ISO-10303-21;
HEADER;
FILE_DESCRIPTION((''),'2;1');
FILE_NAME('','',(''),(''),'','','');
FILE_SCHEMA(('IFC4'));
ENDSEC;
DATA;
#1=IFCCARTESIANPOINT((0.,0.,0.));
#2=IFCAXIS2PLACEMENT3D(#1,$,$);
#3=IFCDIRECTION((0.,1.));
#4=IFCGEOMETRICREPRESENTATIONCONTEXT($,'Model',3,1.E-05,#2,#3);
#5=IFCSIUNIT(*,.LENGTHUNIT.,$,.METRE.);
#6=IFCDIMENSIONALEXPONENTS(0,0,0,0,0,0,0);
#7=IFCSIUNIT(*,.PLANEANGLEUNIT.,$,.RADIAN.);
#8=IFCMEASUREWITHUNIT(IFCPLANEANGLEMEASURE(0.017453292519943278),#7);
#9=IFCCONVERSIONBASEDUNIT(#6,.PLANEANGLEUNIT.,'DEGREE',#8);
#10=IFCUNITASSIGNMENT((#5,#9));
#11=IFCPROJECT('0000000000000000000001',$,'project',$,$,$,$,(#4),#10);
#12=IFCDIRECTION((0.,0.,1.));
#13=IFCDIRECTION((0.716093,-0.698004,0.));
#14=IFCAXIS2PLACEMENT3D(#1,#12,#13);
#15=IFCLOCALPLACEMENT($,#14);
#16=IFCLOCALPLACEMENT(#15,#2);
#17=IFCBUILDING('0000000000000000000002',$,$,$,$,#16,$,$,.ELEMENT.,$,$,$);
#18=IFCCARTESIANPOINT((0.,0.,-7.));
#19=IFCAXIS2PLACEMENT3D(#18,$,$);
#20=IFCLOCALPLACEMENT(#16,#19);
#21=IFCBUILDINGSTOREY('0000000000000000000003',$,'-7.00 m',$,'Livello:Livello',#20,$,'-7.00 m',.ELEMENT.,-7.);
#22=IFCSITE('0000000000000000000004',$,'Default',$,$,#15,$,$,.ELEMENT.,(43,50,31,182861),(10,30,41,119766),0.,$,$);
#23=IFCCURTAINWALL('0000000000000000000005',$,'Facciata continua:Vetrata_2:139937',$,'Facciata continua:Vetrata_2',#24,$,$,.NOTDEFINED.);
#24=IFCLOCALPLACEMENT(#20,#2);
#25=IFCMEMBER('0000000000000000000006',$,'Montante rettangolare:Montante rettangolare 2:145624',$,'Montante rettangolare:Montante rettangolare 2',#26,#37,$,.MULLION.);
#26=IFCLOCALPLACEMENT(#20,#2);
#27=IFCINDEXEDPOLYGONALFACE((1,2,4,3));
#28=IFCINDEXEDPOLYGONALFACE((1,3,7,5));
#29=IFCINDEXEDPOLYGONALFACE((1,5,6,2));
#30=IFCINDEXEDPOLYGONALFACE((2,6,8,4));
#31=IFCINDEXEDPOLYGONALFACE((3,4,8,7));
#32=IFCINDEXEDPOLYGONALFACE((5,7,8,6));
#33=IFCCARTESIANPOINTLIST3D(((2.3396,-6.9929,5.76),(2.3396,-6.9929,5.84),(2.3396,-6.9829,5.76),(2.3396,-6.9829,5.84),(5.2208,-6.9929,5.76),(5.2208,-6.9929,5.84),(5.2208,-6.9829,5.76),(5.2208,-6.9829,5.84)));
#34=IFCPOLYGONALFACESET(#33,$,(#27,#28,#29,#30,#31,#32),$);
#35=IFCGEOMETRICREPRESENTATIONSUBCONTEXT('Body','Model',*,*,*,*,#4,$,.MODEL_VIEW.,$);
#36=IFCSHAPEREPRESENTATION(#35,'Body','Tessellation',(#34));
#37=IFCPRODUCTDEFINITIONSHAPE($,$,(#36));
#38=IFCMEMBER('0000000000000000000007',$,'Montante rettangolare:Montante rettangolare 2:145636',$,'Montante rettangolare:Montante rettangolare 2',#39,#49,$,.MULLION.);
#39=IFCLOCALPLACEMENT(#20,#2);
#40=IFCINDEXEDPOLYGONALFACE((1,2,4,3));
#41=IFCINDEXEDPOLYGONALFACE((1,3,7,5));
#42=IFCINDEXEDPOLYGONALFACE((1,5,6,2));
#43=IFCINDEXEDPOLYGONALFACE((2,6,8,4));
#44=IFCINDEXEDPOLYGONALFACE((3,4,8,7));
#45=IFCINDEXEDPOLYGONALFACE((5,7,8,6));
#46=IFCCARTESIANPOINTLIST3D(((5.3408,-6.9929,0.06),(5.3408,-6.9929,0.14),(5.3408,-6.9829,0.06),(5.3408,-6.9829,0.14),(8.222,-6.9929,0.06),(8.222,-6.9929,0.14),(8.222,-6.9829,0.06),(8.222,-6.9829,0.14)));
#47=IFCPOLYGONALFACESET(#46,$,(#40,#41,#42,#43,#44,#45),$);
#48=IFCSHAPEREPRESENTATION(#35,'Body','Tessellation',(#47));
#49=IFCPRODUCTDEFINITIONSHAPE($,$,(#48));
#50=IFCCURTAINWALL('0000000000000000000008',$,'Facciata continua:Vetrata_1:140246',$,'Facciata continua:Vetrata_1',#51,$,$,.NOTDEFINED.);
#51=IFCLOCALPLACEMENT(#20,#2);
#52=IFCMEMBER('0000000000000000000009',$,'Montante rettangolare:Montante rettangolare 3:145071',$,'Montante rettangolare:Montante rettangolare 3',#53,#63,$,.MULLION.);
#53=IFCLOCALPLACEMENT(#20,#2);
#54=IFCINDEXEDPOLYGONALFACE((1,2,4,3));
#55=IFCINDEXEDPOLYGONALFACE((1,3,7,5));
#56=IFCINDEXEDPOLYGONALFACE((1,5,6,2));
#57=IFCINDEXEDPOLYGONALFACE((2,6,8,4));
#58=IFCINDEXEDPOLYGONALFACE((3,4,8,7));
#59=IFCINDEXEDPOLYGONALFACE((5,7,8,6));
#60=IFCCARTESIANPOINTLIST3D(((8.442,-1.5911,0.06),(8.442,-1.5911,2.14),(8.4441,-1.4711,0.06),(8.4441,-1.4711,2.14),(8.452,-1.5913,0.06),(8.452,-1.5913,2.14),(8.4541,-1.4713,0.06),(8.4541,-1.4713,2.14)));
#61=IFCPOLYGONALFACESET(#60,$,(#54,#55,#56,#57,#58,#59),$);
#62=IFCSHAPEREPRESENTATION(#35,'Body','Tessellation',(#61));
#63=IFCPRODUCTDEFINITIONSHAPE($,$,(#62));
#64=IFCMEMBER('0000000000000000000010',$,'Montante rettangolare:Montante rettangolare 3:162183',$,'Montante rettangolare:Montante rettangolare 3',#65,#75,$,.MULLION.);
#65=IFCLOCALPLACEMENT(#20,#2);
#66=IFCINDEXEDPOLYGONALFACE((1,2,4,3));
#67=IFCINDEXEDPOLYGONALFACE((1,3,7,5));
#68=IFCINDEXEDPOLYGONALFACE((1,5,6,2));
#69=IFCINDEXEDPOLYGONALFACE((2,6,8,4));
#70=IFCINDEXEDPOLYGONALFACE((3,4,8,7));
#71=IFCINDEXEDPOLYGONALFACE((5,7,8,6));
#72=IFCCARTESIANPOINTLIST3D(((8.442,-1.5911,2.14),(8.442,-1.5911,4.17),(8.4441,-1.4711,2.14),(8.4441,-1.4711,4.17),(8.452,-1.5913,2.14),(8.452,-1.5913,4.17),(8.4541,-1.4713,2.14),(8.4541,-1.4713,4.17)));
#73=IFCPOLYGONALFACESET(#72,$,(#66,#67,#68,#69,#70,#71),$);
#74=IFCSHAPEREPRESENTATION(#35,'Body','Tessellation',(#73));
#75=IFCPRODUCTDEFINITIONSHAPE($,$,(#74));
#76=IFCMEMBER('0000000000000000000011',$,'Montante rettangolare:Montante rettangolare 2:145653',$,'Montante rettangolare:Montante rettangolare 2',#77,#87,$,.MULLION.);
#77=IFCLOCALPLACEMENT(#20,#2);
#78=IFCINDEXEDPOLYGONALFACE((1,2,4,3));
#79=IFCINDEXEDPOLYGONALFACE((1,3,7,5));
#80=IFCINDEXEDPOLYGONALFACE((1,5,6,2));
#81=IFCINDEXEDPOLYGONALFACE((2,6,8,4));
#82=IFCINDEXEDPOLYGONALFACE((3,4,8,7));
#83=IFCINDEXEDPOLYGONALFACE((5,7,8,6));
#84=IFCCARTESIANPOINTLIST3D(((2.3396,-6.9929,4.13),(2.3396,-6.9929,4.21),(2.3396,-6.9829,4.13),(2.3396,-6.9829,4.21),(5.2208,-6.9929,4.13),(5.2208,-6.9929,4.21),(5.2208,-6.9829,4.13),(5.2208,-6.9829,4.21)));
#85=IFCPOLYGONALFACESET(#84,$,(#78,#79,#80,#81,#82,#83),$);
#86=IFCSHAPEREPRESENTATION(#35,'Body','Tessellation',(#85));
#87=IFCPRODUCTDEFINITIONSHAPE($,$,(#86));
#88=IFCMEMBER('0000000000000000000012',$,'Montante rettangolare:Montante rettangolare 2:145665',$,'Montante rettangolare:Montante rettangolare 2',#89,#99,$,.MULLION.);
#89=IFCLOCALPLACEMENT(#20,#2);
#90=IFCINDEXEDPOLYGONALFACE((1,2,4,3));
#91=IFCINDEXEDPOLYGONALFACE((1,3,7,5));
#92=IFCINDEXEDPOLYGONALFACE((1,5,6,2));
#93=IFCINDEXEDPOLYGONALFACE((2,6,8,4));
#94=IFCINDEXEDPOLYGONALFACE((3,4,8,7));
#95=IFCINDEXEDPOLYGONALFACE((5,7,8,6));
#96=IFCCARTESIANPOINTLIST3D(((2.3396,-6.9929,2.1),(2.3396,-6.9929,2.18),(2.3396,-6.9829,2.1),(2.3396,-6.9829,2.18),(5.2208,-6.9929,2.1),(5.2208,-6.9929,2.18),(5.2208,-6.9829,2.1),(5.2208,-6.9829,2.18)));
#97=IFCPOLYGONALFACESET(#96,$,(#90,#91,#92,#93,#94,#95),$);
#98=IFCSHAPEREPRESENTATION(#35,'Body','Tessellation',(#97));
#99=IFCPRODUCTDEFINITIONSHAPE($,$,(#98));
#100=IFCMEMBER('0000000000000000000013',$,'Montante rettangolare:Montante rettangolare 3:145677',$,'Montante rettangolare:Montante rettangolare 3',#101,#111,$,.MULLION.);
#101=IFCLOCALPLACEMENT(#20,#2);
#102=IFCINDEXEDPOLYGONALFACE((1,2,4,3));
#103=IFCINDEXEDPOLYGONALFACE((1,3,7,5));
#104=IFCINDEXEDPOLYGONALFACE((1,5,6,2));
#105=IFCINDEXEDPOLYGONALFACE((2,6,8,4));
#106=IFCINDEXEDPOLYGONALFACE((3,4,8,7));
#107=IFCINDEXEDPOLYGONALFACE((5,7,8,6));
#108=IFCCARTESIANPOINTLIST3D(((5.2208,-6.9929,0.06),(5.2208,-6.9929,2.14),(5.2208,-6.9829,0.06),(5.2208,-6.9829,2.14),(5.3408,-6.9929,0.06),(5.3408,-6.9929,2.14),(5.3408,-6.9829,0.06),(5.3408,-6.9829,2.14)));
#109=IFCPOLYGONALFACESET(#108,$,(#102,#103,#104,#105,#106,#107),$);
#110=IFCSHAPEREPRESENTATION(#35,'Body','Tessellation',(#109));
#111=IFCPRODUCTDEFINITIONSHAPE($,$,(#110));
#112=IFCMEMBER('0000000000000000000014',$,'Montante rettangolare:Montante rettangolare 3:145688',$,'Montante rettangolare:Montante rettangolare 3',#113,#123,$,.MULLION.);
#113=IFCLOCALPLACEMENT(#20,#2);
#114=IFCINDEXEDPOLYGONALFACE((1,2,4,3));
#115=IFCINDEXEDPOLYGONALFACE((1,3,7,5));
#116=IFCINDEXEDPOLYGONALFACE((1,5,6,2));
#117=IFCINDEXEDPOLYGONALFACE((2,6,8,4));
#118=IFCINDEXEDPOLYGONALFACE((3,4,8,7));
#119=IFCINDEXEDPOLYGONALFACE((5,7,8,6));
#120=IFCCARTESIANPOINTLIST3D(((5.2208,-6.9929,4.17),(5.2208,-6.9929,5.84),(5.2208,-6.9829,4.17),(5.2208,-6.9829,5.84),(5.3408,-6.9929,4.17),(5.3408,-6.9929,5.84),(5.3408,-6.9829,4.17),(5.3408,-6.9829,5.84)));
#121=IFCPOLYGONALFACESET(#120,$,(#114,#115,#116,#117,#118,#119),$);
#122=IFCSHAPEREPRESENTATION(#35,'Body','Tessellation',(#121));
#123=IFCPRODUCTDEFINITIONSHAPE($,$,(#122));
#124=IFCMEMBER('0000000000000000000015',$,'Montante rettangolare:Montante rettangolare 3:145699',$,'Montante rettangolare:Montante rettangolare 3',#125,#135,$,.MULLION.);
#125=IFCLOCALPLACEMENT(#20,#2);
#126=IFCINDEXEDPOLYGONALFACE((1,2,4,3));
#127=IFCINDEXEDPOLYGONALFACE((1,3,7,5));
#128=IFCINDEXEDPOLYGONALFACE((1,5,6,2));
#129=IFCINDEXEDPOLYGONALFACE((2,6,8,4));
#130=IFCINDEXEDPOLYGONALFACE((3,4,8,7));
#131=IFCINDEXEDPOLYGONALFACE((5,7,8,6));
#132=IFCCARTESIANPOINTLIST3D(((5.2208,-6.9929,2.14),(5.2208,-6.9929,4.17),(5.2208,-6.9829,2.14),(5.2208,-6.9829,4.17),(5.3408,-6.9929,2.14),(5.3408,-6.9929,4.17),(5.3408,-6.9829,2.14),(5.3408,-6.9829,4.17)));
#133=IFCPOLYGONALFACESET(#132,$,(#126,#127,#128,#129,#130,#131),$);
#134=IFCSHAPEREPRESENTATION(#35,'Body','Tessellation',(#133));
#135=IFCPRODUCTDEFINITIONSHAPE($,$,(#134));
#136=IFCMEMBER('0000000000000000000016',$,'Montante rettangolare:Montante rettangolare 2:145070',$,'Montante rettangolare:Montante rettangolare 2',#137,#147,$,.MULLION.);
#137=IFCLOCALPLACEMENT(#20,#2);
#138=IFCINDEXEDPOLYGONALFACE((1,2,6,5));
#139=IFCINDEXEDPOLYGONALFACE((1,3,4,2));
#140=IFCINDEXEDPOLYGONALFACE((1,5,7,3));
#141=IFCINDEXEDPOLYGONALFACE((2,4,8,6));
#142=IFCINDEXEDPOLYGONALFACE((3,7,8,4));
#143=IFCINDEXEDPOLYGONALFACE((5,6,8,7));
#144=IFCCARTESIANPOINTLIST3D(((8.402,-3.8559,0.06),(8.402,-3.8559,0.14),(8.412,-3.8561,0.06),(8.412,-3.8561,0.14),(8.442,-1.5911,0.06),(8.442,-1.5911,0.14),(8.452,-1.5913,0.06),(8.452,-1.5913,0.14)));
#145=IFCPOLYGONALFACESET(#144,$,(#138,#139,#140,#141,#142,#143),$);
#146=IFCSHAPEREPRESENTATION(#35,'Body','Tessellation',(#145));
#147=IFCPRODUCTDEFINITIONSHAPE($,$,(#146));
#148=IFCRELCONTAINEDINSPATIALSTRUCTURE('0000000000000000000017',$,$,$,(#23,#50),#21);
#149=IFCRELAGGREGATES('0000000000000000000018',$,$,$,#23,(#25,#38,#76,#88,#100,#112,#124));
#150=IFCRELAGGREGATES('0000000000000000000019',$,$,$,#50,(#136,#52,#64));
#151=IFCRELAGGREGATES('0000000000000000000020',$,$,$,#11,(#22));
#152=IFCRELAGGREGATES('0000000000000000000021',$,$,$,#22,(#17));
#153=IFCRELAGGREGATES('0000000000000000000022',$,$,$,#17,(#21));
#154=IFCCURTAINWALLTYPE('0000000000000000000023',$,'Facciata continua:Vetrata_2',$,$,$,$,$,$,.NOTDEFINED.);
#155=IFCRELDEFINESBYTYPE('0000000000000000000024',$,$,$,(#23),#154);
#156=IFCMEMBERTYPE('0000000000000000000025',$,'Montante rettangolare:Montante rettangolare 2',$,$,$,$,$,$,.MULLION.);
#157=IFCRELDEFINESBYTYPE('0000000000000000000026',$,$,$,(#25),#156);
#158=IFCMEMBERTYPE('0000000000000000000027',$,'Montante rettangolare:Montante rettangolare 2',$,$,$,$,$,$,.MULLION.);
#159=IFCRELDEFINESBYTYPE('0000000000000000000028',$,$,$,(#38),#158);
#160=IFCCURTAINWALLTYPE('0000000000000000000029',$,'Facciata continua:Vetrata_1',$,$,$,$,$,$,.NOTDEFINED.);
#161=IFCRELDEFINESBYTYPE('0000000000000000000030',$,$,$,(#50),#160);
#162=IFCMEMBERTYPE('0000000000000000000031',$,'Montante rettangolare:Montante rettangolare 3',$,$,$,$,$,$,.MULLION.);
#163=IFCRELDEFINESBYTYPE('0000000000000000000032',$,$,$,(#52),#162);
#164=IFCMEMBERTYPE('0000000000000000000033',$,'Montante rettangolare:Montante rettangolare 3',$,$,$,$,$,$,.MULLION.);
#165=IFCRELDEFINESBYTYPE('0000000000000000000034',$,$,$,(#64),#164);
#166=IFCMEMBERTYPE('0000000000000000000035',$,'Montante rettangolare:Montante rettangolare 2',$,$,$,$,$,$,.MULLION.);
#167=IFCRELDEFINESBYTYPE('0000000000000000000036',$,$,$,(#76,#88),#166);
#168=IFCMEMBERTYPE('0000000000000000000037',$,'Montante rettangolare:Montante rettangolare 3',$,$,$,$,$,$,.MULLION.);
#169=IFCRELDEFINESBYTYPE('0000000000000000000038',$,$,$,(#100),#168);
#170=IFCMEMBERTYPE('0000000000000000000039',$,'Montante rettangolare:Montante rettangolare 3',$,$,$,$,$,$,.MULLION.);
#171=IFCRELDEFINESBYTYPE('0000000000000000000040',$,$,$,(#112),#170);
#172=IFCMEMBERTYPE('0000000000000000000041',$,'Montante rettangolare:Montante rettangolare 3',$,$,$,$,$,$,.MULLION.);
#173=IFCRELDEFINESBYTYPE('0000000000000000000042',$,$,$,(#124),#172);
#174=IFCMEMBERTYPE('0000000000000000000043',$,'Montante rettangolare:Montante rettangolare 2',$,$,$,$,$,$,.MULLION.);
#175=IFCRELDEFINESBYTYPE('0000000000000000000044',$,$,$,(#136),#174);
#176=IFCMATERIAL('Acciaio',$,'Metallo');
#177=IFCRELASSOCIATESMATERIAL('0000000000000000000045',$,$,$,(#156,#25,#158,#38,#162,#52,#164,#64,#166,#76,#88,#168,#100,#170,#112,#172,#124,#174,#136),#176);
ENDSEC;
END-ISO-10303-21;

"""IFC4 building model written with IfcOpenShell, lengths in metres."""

from ifc_helpers import new_model, entity, si_unit, converted_unit, direction, frame, origin, place, context, subcontext, project, spatial, indexed_curve, outline, extrude, source, transform, mapped, material, type_object, type_shapes, element, aggregate, save


model = new_model("IFC4")

# Units and contexts
model_context = context("Model", 3, precision=1e-05, world=origin(), true_north=direction((0.0, 1.0)))
body_context = subcontext(model_context, "Body", "Model", "MODEL_VIEW")
ifc_project = project(units=[si_unit("LENGTHUNIT", "METRE"), converted_unit("PLANEANGLEUNIT", "DEGREE", entity("IfcPlaneAngleMeasure", 0.017453292519943278), si_unit("PLANEANGLEUNIT", "RADIAN"), dimensions=[0, 0, 0, 0, 0, 0, 0])], contexts=[model_context])

# Site, building, storey
site_placement = place(None, frame((0.0, 0.0, 0.0), z_axis=(0.0, 0.0, 1.0), x_axis=(0.716093, -0.698004, 0.0)))
site = spatial("IfcSite", under=ifc_project, at=site_placement, Name="Default", CompositionType="ELEMENT", RefLatitude=(43, 50, 31, 182861), RefLongitude=(10, 30, 41, 119766), RefElevation=0.0)
building_placement = place(site_placement, origin())
building = spatial("IfcBuilding", under=site, at=building_placement, CompositionType="ELEMENT")
storey_placement = place(building_placement, frame((0.0, 0.0, -7.0)))
storey = spatial("IfcBuildingStorey", under=building, at=storey_placement, Name="-7.00 m", ObjectType="Livello:Livello", LongName="-7.00 m", CompositionType="ELEMENT", Elevation=-7.0)

# Curtain walls, members
curtain_wall_type_1 = type_object("IfcCurtainWallType", Name="Facciata continua:Vetrata_2", PredefinedType="NOTDEFINED")
curtain_wall_1_placement = place(storey_placement, frame((0.0, 0.0, 7.0)))
curtain_wall_1 = element("IfcCurtainWall", 1, at=curtain_wall_1_placement, inside=storey, type_object=curtain_wall_type_1, Name="Facciata continua:Vetrata_2:139937", ObjectType="Facciata continua:Vetrata_2", PredefinedType="NOTDEFINED")
ifc_material_1 = material(Name="Acciaio", Category="Metallo")
member_type_1 = type_object("IfcMemberType", Name="Montante rettangolare:Montante rettangolare 2", PredefinedType="MULLION", material=ifc_material_1)
shared_shape_1 = source(origin(), body_context, "Body", "SweptSolid", [
    extrude(outline(indexed_curve([(-0.04, -0.005), (0.04, -0.005), (0.04, 0.005), (-0.04, 0.005), (-0.04, -0.005)], self_intersect=False)), frame((-0.04, 0.01, -2.8812), z_axis=(0.0, 0.0, 1.0), x_axis=(-1.0, 0.0, 0.0)), (0.0, 0.0, 1.0), 2.8812),
])
type_shapes(member_type_1, [shared_shape_1])
member_1_placement = place(curtain_wall_1_placement, frame((5.2208, -6.9779, -1.16), z_axis=(1.0, 0.0, 0.0), x_axis=(0.0, 0.0, 1.0)))
member_1 = element("IfcMember", 2, at=member_1_placement, type_object=member_type_1, material=ifc_material_1, Name="Montante rettangolare:Montante rettangolare 2:145624", ObjectType="Montante rettangolare:Montante rettangolare 2", PredefinedType="MULLION", context=body_context, shape_type="MappedRepresentation", body=[
    mapped(shared_shape_1, transform((0.0, 0.0, 0.0), scale=1.0)),
])
member_type_2 = type_object("IfcMemberType", Name="Montante rettangolare:Montante rettangolare 2", PredefinedType="MULLION", material=ifc_material_1)
shared_shape_2 = source(origin(), body_context, "Body", "SweptSolid", [
    extrude(outline(indexed_curve([(-0.04, -0.005), (0.04, -0.005), (0.04, 0.005), (-0.04, 0.005), (-0.04, -0.005)], self_intersect=False)), frame((-0.04, 0.01, -2.8812), z_axis=(0.0, 0.0, 1.0), x_axis=(-1.0, 0.0, 0.0)), (0.0, 0.0, 1.0), 2.8812),
])
type_shapes(member_type_2, [shared_shape_2])
member_2_placement = place(curtain_wall_1_placement, frame((5.3408, -6.9779, -6.94), z_axis=(-1.0, 0.0, 0.0), x_axis=(0.0, 0.0, -1.0)))
member_2 = element("IfcMember", 3, at=member_2_placement, type_object=member_type_2, material=ifc_material_1, Name="Montante rettangolare:Montante rettangolare 2:145636", ObjectType="Montante rettangolare:Montante rettangolare 2", PredefinedType="MULLION", context=body_context, shape_type="MappedRepresentation", body=[
    mapped(shared_shape_2, transform((0.0, 0.0, 0.0), scale=1.0)),
])
curtain_wall_type_2 = type_object("IfcCurtainWallType", Name="Facciata continua:Vetrata_1", PredefinedType="NOTDEFINED")
curtain_wall_2_placement = place(storey_placement, frame((0.0, 0.0, 7.0)))
curtain_wall_2 = element("IfcCurtainWall", 4, at=curtain_wall_2_placement, inside=storey, type_object=curtain_wall_type_2, Name="Facciata continua:Vetrata_1:140246", ObjectType="Facciata continua:Vetrata_1", PredefinedType="NOTDEFINED")
member_type_3 = type_object("IfcMemberType", Name="Montante rettangolare:Montante rettangolare 3", PredefinedType="MULLION", material=ifc_material_1)
shared_shape_3 = source(origin(), body_context, "Body", "SweptSolid", [
    extrude(outline(indexed_curve([(-0.06, -0.005), (0.06, -0.005), (0.06, 0.005), (-0.06, 0.005), (-0.06, -0.005)], self_intersect=False)), frame((-0.06, 0.01, -2.08), z_axis=(0.0, 0.0, 1.0), x_axis=(-1.0, 0.0, 0.0)), (0.0, 0.0, 1.0), 2.08),
])
type_shapes(member_type_3, [shared_shape_3])
member_3_placement = place(curtain_wall_2_placement, frame((8.4391, -1.471, -6.94), z_axis=(0.0, 0.0, -1.0), x_axis=(0.017636, 0.999844, 0.0)))
member_3 = element("IfcMember", 5, at=member_3_placement, type_object=member_type_3, material=ifc_material_1, Name="Montante rettangolare:Montante rettangolare 3:145071", ObjectType="Montante rettangolare:Montante rettangolare 3", PredefinedType="MULLION", context=body_context, shape_type="MappedRepresentation", body=[
    mapped(shared_shape_3, transform((0.0, 0.0, 0.0), scale=1.0)),
])
member_type_4 = type_object("IfcMemberType", Name="Montante rettangolare:Montante rettangolare 3", PredefinedType="MULLION", material=ifc_material_1)
shared_shape_4 = source(origin(), body_context, "Body", "SweptSolid", [
    extrude(outline(indexed_curve([(-0.06, -0.005), (0.06, -0.005), (0.06, 0.005), (-0.06, 0.005), (-0.06, -0.005)], self_intersect=False)), frame((-0.06, 0.01, -2.03), z_axis=(0.0, 0.0, 1.0), x_axis=(-1.0, 0.0, 0.0)), (0.0, 0.0, 1.0), 2.03),
])
type_shapes(member_type_4, [shared_shape_4])
member_4_placement = place(curtain_wall_2_placement, frame((8.4391, -1.471, -4.86), z_axis=(0.0, 0.0, -1.0), x_axis=(0.017636, 0.999844, 0.0)))
member_4 = element("IfcMember", 6, at=member_4_placement, type_object=member_type_4, material=ifc_material_1, Name="Montante rettangolare:Montante rettangolare 3:162183", ObjectType="Montante rettangolare:Montante rettangolare 3", PredefinedType="MULLION", context=body_context, shape_type="MappedRepresentation", body=[
    mapped(shared_shape_4, transform((0.0, 0.0, 0.0), scale=1.0)),
])

# Members
member_type_5 = type_object("IfcMemberType", Name="Montante rettangolare:Montante rettangolare 2", PredefinedType="MULLION", material=ifc_material_1)
shared_shape_5 = source(origin(), body_context, "Body", "SweptSolid", [
    extrude(outline(indexed_curve([(-0.04, -0.005), (0.04, -0.005), (0.04, 0.005), (-0.04, 0.005), (-0.04, -0.005)], self_intersect=False)), frame((0.0, 0.01, -2.8812), z_axis=(0.0, 0.0, 1.0), x_axis=(-1.0, 0.0, 0.0)), (0.0, 0.0, 1.0), 2.8812),
])
type_shapes(member_type_5, [shared_shape_5])
member_5_placement = place(curtain_wall_1_placement, frame((5.2208, -6.9779, -2.83), z_axis=(1.0, 0.0, 0.0), x_axis=(0.0, 0.0, 1.0)))
member_5 = element("IfcMember", 7, at=member_5_placement, type_object=member_type_5, material=ifc_material_1, Name="Montante rettangolare:Montante rettangolare 2:145653", ObjectType="Montante rettangolare:Montante rettangolare 2", PredefinedType="MULLION", context=body_context, shape_type="MappedRepresentation", body=[
    mapped(shared_shape_5, transform((0.0, 0.0, 0.0), scale=1.0)),
])
member_6_placement = place(curtain_wall_1_placement, frame((5.2208, -6.9779, -4.86), z_axis=(1.0, 0.0, 0.0), x_axis=(0.0, 0.0, 1.0)))
member_6 = element("IfcMember", 8, at=member_6_placement, type_object=member_type_5, material=ifc_material_1, Name="Montante rettangolare:Montante rettangolare 2:145665", ObjectType="Montante rettangolare:Montante rettangolare 2", PredefinedType="MULLION", context=body_context, shape_type="MappedRepresentation", body=[
    mapped(shared_shape_5, transform((0.0, 0.0, 0.0), scale=1.0)),
])
member_type_6 = type_object("IfcMemberType", Name="Montante rettangolare:Montante rettangolare 3", PredefinedType="MULLION", material=ifc_material_1)
shared_shape_6 = source(origin(), body_context, "Body", "SweptSolid", [
    extrude(outline(indexed_curve([(-0.06, -0.005), (0.06, -0.005), (0.06, 0.005), (-0.06, 0.005), (-0.06, -0.005)], self_intersect=False)), frame((0.0, 0.01, -2.08), z_axis=(0.0, 0.0, 1.0), x_axis=(-1.0, 0.0, 0.0)), (0.0, 0.0, 1.0), 2.08),
])
type_shapes(member_type_6, [shared_shape_6])
member_7_placement = place(curtain_wall_1_placement, frame((5.2808, -6.9779, -6.94), z_axis=(0.0, 0.0, -1.0), x_axis=(1.0, 0.0, 0.0)))
member_7 = element("IfcMember", 9, at=member_7_placement, type_object=member_type_6, material=ifc_material_1, Name="Montante rettangolare:Montante rettangolare 3:145677", ObjectType="Montante rettangolare:Montante rettangolare 3", PredefinedType="MULLION", context=body_context, shape_type="MappedRepresentation", body=[
    mapped(shared_shape_6, transform((0.0, 0.0, 0.0), scale=1.0)),
])
member_type_7 = type_object("IfcMemberType", Name="Montante rettangolare:Montante rettangolare 3", PredefinedType="MULLION", material=ifc_material_1)
shared_shape_7 = source(origin(), body_context, "Body", "SweptSolid", [
    extrude(outline(indexed_curve([(-0.06, -0.005), (0.06, -0.005), (0.06, 0.005), (-0.06, 0.005), (-0.06, -0.005)], self_intersect=False)), frame((0.0, 0.01, -1.67), z_axis=(0.0, 0.0, 1.0), x_axis=(-1.0, 0.0, 0.0)), (0.0, 0.0, 1.0), 1.67),
])
type_shapes(member_type_7, [shared_shape_7])
member_8_placement = place(curtain_wall_1_placement, frame((5.2808, -6.9779, -2.83), z_axis=(0.0, 0.0, -1.0), x_axis=(1.0, 0.0, 0.0)))
member_8 = element("IfcMember", 10, at=member_8_placement, type_object=member_type_7, material=ifc_material_1, Name="Montante rettangolare:Montante rettangolare 3:145688", ObjectType="Montante rettangolare:Montante rettangolare 3", PredefinedType="MULLION", context=body_context, shape_type="MappedRepresentation", body=[
    mapped(shared_shape_7, transform((0.0, 0.0, 0.0), scale=1.0)),
])
member_type_8 = type_object("IfcMemberType", Name="Montante rettangolare:Montante rettangolare 3", PredefinedType="MULLION", material=ifc_material_1)
shared_shape_8 = source(origin(), body_context, "Body", "SweptSolid", [
    extrude(outline(indexed_curve([(-0.06, -0.005), (0.06, -0.005), (0.06, 0.005), (-0.06, 0.005), (-0.06, -0.005)], self_intersect=False)), frame((0.0, 0.01, -2.03), z_axis=(0.0, 0.0, 1.0), x_axis=(-1.0, 0.0, 0.0)), (0.0, 0.0, 1.0), 2.03),
])
type_shapes(member_type_8, [shared_shape_8])
member_9_placement = place(curtain_wall_1_placement, frame((5.2808, -6.9779, -4.86), z_axis=(0.0, 0.0, -1.0), x_axis=(1.0, 0.0, 0.0)))
member_9 = element("IfcMember", 11, at=member_9_placement, type_object=member_type_8, material=ifc_material_1, Name="Montante rettangolare:Montante rettangolare 3:145699", ObjectType="Montante rettangolare:Montante rettangolare 3", PredefinedType="MULLION", context=body_context, shape_type="MappedRepresentation", body=[
    mapped(shared_shape_8, transform((0.0, 0.0, 0.0), scale=1.0)),
])
aggregate(curtain_wall_1, [member_1, member_2, member_5, member_6, member_7, member_8, member_9])
member_type_9 = type_object("IfcMemberType", Name="Montante rettangolare:Montante rettangolare 2", PredefinedType="MULLION", material=ifc_material_1)
shared_shape_9 = source(origin(), body_context, "Body", "SweptSolid", [
    extrude(outline(indexed_curve([(-0.04, -0.005), (0.04, -0.005), (0.04, 0.005), (-0.04, 0.005), (-0.04, -0.005)], self_intersect=False)), frame((-0.04, 0.01, -2.2652), z_axis=(0.0, 0.0, 1.0), x_axis=(-1.0, 0.0, 0.0)), (0.0, 0.0, 1.0), 2.2652),
])
type_shapes(member_type_9, [shared_shape_9])
member_10_placement = place(curtain_wall_2_placement, frame((8.397, -3.8558, -6.94), z_axis=(-0.017636, -0.999844, 0.0), x_axis=(0.0, 0.0, -1.0)))
member_10 = element("IfcMember", 12, at=member_10_placement, type_object=member_type_9, material=ifc_material_1, Name="Montante rettangolare:Montante rettangolare 2:145070", ObjectType="Montante rettangolare:Montante rettangolare 2", PredefinedType="MULLION", context=body_context, shape_type="MappedRepresentation", body=[
    mapped(shared_shape_9, transform((0.0, 0.0, 0.0), scale=1.0)),
])

aggregate(curtain_wall_2, [member_10, member_3, member_4])

save(model, "model.ifc")
